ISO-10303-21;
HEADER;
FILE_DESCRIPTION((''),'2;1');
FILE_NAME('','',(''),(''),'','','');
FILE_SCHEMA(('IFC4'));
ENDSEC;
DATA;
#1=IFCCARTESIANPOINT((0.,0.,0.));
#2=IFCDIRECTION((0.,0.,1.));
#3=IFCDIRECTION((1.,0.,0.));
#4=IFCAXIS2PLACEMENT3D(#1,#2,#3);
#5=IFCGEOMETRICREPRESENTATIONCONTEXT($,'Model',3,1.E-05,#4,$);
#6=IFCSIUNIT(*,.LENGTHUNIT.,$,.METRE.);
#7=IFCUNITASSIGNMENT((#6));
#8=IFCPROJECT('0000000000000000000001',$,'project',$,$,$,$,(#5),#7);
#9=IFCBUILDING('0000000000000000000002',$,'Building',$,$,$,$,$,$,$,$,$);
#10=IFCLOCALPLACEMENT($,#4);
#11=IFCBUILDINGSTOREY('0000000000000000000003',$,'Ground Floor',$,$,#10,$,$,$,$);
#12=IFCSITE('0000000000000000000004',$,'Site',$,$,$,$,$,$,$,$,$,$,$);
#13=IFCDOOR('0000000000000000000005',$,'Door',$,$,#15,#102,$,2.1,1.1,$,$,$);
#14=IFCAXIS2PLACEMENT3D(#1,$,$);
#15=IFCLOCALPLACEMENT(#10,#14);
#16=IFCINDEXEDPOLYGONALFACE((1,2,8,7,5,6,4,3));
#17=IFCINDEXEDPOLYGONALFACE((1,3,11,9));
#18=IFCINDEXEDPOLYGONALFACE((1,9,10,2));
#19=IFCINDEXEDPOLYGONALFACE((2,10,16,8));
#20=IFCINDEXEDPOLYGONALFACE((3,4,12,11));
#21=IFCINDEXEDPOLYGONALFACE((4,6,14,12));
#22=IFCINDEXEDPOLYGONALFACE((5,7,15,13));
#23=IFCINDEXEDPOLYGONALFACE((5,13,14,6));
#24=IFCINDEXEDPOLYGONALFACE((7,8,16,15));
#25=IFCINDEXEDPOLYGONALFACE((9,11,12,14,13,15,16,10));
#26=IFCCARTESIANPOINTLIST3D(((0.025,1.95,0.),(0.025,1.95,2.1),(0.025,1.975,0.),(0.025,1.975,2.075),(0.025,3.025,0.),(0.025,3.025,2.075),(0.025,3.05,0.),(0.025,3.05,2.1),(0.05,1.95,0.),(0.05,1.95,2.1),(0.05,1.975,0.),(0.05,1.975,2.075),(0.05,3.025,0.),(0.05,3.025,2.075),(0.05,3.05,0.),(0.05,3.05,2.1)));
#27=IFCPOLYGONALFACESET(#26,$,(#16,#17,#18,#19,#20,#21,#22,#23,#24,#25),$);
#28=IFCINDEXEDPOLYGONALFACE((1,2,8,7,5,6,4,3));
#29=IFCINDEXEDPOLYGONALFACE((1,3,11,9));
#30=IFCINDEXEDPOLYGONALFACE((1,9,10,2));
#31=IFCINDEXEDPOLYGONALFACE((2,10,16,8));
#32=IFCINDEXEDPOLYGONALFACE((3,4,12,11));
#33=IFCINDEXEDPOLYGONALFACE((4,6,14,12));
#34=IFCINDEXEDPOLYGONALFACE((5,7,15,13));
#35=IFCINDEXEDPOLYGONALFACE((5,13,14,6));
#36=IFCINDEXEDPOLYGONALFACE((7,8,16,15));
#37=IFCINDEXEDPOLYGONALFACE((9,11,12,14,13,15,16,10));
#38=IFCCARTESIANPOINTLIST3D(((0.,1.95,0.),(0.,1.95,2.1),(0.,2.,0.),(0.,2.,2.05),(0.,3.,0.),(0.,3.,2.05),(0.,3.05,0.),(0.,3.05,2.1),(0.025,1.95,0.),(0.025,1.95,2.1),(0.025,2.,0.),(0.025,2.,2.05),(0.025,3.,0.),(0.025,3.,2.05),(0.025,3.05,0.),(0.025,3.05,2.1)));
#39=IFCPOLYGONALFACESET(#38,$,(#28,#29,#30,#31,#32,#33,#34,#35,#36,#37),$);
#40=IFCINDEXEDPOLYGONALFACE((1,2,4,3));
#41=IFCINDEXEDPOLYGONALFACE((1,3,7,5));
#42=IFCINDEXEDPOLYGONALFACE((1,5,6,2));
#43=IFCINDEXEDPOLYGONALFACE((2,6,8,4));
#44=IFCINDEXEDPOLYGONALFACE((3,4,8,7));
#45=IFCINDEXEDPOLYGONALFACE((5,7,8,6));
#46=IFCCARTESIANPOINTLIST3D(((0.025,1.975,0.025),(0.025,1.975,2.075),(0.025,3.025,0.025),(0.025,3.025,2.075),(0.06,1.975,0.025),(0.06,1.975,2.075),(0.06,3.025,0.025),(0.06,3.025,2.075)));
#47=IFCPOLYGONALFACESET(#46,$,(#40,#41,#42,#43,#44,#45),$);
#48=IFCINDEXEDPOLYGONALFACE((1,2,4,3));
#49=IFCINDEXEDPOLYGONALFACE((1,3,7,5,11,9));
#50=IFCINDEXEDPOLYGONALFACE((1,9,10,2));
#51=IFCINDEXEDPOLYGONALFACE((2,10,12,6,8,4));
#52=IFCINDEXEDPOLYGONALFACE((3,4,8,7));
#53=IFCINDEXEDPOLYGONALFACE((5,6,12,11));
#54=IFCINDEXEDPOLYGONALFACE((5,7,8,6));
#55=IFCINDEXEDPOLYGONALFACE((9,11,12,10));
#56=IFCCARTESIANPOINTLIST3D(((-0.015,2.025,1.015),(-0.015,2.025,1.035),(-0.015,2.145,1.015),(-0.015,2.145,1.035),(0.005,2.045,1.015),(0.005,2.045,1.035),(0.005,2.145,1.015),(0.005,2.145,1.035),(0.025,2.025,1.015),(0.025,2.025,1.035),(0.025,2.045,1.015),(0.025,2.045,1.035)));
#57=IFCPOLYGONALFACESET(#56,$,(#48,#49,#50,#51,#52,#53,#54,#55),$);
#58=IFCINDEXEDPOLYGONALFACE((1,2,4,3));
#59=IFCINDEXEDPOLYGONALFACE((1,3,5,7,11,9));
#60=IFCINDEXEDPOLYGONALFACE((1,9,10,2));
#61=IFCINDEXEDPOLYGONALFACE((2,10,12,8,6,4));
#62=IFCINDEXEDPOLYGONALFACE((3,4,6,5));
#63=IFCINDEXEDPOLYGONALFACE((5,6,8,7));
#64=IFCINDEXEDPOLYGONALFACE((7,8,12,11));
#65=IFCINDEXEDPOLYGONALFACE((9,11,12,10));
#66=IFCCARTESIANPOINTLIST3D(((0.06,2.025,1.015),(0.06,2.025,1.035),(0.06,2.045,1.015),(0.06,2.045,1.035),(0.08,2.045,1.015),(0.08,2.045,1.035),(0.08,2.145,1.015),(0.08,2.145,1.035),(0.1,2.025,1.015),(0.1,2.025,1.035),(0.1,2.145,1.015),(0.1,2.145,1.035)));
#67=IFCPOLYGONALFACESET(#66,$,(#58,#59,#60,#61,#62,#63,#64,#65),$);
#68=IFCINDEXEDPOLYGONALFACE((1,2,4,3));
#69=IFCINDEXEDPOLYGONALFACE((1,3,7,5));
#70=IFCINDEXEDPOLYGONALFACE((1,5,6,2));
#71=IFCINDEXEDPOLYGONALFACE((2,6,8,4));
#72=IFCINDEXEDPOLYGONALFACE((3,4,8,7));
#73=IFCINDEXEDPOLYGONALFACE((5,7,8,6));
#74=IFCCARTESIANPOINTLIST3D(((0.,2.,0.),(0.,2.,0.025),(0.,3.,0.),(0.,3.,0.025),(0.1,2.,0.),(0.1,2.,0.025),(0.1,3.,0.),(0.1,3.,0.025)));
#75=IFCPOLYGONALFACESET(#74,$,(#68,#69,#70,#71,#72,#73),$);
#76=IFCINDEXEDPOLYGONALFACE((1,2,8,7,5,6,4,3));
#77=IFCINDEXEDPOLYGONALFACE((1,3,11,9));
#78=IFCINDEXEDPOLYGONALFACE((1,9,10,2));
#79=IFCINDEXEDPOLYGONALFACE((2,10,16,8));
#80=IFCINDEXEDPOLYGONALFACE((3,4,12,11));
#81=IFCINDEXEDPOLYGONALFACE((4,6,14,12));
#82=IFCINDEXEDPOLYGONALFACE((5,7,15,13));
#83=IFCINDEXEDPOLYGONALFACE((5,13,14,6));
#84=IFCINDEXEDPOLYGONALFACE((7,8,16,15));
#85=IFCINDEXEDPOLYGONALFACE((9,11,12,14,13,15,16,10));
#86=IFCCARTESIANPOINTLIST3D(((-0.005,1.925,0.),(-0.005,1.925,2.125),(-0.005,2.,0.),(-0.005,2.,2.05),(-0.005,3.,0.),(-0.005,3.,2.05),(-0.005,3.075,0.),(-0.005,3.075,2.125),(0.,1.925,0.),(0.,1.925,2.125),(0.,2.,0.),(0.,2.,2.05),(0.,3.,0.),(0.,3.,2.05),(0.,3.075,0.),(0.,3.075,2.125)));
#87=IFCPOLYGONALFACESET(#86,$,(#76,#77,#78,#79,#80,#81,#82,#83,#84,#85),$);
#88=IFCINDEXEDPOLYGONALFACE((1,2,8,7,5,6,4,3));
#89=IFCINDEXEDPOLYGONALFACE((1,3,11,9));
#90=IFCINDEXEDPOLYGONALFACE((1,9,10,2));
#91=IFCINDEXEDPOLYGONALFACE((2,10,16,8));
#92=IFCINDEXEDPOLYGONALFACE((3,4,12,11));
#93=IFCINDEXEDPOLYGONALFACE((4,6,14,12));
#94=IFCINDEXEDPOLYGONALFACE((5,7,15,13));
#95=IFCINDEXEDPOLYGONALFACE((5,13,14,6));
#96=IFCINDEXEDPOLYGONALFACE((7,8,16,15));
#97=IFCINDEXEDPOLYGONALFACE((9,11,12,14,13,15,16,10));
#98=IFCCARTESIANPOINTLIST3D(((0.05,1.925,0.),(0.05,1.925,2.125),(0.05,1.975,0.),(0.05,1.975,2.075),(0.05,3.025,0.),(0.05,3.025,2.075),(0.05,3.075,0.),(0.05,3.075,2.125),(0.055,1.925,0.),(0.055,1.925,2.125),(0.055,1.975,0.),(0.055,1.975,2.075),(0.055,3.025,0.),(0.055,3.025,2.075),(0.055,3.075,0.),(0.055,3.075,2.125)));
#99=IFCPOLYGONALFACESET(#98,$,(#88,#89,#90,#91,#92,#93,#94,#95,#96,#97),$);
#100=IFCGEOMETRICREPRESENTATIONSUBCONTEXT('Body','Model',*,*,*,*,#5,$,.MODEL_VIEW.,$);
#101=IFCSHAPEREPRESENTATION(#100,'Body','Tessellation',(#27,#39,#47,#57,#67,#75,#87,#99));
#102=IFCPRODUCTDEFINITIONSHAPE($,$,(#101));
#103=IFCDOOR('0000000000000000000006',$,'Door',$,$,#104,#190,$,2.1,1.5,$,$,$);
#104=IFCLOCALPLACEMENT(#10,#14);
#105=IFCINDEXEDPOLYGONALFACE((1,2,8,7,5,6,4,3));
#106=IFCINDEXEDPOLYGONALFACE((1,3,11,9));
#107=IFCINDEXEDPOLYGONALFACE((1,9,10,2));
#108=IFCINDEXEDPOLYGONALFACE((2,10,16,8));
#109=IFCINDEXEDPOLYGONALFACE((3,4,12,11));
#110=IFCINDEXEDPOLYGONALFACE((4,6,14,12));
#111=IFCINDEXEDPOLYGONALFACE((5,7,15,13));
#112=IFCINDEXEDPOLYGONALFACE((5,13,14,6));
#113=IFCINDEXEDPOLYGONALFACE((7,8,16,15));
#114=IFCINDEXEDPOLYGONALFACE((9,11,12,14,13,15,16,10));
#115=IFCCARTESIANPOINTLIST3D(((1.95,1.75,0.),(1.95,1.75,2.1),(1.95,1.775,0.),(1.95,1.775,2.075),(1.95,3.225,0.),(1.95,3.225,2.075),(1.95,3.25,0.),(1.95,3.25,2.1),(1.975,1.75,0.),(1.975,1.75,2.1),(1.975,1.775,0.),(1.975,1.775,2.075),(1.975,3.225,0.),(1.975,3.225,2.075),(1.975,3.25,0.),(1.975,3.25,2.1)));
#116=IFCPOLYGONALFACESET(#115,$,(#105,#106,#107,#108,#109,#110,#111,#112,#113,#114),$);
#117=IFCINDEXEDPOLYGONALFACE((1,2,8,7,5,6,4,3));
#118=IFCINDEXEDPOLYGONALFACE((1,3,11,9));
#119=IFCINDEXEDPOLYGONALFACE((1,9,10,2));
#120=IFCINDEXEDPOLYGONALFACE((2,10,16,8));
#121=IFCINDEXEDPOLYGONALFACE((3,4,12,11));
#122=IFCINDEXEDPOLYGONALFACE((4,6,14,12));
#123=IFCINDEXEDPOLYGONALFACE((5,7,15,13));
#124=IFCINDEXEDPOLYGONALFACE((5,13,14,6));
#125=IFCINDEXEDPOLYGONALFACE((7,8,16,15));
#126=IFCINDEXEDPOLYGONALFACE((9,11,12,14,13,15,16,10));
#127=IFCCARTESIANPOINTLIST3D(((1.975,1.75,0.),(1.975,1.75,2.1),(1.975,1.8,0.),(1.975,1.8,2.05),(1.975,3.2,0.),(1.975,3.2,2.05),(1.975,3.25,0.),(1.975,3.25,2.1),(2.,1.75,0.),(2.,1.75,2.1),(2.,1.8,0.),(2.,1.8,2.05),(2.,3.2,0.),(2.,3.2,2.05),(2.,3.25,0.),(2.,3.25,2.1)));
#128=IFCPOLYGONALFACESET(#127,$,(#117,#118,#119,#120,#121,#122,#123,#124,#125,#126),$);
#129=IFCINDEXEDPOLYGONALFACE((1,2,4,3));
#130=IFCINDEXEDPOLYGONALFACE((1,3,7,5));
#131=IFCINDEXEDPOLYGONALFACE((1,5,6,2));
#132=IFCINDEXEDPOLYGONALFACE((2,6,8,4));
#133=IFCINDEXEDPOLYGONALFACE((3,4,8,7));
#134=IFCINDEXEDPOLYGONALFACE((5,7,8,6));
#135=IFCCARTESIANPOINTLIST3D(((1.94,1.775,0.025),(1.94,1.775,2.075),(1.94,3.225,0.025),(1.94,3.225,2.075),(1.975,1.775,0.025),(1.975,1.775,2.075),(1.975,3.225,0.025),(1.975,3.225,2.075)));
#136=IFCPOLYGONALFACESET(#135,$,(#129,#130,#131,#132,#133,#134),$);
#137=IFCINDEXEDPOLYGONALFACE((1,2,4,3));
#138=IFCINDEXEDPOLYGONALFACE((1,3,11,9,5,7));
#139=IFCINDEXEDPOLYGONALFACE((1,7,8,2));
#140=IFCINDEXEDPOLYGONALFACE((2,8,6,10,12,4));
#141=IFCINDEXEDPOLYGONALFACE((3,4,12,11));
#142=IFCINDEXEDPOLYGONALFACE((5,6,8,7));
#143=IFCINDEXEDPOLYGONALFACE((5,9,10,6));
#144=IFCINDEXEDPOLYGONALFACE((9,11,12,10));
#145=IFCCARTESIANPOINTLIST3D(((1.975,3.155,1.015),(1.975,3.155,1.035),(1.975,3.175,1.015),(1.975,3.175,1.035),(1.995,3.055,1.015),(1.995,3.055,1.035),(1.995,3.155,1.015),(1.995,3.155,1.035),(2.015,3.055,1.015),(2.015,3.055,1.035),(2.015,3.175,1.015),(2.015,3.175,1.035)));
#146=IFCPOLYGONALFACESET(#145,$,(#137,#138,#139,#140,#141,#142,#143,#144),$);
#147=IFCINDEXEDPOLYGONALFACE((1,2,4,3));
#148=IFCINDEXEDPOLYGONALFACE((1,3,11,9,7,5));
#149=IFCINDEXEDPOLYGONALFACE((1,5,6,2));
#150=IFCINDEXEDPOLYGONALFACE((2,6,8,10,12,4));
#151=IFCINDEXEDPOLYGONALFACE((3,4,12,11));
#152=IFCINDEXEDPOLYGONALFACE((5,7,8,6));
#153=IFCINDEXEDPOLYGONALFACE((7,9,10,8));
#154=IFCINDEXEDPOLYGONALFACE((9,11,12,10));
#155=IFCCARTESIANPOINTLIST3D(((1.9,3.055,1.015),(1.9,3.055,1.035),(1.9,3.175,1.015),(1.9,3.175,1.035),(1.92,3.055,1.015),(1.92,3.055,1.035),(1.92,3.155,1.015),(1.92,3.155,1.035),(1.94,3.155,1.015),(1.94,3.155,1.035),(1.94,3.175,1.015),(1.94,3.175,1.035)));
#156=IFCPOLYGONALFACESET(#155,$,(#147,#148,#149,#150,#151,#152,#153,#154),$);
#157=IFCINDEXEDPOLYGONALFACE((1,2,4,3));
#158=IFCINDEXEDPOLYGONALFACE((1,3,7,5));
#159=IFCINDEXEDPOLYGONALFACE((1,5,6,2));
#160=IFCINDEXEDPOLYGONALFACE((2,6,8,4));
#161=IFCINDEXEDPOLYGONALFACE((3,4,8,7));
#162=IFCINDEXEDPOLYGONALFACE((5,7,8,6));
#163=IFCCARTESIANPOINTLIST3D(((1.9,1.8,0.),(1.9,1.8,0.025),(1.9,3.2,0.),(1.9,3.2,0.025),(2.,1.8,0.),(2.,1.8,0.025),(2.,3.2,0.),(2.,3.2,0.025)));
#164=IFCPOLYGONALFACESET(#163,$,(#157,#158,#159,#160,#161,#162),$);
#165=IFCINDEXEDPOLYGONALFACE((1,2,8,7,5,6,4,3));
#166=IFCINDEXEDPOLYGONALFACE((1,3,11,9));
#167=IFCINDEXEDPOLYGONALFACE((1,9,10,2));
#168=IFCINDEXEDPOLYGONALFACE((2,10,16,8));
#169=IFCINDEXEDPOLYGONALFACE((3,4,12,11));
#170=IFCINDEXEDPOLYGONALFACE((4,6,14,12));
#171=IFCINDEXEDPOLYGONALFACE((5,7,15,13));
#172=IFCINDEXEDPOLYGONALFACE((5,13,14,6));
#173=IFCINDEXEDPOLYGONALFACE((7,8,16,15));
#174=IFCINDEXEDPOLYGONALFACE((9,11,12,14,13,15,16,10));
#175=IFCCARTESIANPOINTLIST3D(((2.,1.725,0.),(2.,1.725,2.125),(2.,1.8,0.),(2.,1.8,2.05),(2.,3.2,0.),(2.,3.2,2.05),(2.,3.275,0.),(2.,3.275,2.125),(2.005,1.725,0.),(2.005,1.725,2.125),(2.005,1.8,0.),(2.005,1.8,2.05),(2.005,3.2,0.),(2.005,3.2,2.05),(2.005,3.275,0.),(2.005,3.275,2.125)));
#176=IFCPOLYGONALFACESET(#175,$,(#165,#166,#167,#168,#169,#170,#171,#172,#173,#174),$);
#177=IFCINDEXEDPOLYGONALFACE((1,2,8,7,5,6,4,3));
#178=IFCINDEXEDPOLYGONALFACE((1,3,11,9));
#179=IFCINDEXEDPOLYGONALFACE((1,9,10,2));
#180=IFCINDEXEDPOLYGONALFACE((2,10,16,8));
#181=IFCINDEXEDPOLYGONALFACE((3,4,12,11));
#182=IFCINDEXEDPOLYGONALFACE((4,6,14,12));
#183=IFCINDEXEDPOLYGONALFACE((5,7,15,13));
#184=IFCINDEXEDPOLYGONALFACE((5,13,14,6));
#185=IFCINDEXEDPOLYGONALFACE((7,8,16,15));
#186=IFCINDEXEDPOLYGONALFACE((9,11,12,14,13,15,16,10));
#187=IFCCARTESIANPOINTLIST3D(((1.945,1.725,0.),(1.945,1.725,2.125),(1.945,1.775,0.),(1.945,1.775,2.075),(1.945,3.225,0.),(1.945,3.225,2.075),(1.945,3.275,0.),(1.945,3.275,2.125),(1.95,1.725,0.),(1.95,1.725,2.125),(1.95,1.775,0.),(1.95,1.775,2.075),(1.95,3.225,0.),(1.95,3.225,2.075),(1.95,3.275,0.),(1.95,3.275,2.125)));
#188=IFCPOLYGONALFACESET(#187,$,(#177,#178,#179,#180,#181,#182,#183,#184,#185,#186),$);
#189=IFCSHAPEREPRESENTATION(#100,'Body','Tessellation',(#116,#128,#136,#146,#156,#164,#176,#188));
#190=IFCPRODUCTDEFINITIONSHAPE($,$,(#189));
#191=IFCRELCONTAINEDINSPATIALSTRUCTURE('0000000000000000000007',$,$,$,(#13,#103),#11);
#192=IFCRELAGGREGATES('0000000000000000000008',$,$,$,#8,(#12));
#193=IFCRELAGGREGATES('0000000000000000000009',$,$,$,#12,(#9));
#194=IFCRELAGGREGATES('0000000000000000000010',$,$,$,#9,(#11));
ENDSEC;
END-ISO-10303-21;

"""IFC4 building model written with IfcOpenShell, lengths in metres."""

from ifc_helpers import new_model, si_unit, frame, origin_with_axes, place, context, subcontext, project, spatial, line, indexed_curve, outline, extrude, element, save


model = new_model("IFC4")

# Units and contexts
model_context = context("Model", 3, precision=1e-05, world=origin_with_axes())
body_context = subcontext(model_context, "Body", "Model", "MODEL_VIEW")
ifc_project = project(units=[si_unit("LENGTHUNIT", "METRE")], contexts=[model_context])

# Site, building, storey
site = spatial("IfcSite", under=ifc_project, Name="Site")
building = spatial("IfcBuilding", under=site, Name="Building")
storey_placement = place(None, origin_with_axes())
storey = spatial("IfcBuildingStorey", under=building, at=storey_placement, Name="Ground Floor")

# Doors
door_1_placement = place(storey_placement, frame((0.0, 3.05, 0.0), z_axis=(0.0, 0.0, 1.0), x_axis=(0.0, -1.0, 0.0)))
element("IfcDoor", 1, at=door_1_placement, inside=storey, Name="Door", OverallHeight=2.1, OverallWidth=1.1, context=body_context, shape_type="SweptSolid", body=[
    extrude(outline(indexed_curve([(0.0, 0.0), (0.0, 2.1), (1.1, 2.1), (1.1, 0.0), (1.075, 0.0), (1.075, 2.075), (0.025, 2.075), (0.025, 0.0)], segments=[line(1, 2, 3, 4, 5, 6, 7, 8, 1)])), frame((0.0, 0.025, 0.0), z_axis=(0.0, -1.0, 0.0), x_axis=(1.0, 0.0, 0.0)), (0.0, 0.0, -1.0), 0.025),
    extrude(outline(indexed_curve([(0.0, 0.0), (0.0, 2.1), (1.1, 2.1), (1.1, 0.0), (1.05, 0.0), (1.05, 2.05), (0.05, 2.05), (0.05, 0.0)], segments=[line(1, 2, 3, 4, 5, 6, 7, 8, 1)])), frame((0.0, 0.0, 0.0), z_axis=(0.0, -1.0, 0.0), x_axis=(1.0, 0.0, 0.0)), (0.0, 0.0, -1.0), 0.025),
    extrude(outline(indexed_curve([(0.0, 0.0), (1.05, 0.0), (1.05, 0.035), (0.0, 0.035)], segments=[line(1, 2, 3, 4, 1)])), frame((0.025, 0.025, 0.025), z_axis=(0.0, 0.0, 1.0), x_axis=(1.0, 0.0, 0.0)), (0.0, 0.0, 1.0), 2.05),
    extrude(outline(indexed_curve([(0.0, 0.0), (0.0, -0.04), (-0.12, -0.04), (-0.12, -0.02), (-0.02, -0.02), (-0.02, 0.0)], segments=[line(1, 2, 3, 4, 5, 6, 1)])), frame((1.025, 0.025, 1.015), z_axis=(0.0, 0.0, 1.0), x_axis=(1.0, 0.0, 0.0)), (0.0, 0.0, 1.0), 0.02),
    extrude(outline(indexed_curve([(0.0, 0.0), (0.0, 0.04), (-0.12, 0.04), (-0.12, 0.02), (-0.02, 0.02), (-0.02, 0.0)], segments=[line(1, 2, 3, 4, 5, 6, 1)])), frame((1.025, 0.06, 1.015), z_axis=(0.0, 0.0, 1.0), x_axis=(1.0, 0.0, 0.0)), (0.0, 0.0, 1.0), 0.02),
    extrude(outline(indexed_curve([(0.0, 0.0), (1.0, 0.0), (1.0, 0.1), (0.0, 0.1)], segments=[line(1, 2, 3, 4, 1)])), frame((0.05, 0.0, 0.0), z_axis=(0.0, 0.0, 1.0), x_axis=(1.0, 0.0, 0.0)), (0.0, 0.0, 1.0), 0.025),
    extrude(outline(indexed_curve([(0.0, 0.0), (0.0, 2.125), (1.15, 2.125), (1.15, 0.0), (1.075, 0.0), (1.075, 2.05), (0.075, 2.05), (0.075, 0.0)], segments=[line(1, 2, 3, 4, 5, 6, 7, 8, 1)])), frame((-0.025, -0.005, 0.0), z_axis=(0.0, -1.0, 0.0), x_axis=(1.0, 0.0, 0.0)), (0.0, 0.0, -1.0), 0.005),
    extrude(outline(indexed_curve([(0.0, 0.0), (0.0, 2.125), (1.15, 2.125), (1.15, 0.0), (1.1, 0.0), (1.1, 2.075), (0.05, 2.075), (0.05, 0.0)], segments=[line(1, 2, 3, 4, 5, 6, 7, 8, 1)])), frame((-0.025, 0.05, 0.0), z_axis=(0.0, -1.0, 0.0), x_axis=(1.0, 0.0, 0.0)), (0.0, 0.0, -1.0), 0.005),
])
door_2_placement = place(storey_placement, frame((2.0, 1.75, 0.0), z_axis=(0.0, 0.0, 1.0), x_axis=(0.0, 1.0, 0.0)))
element("IfcDoor", 2, at=door_2_placement, inside=storey, Name="Door", OverallHeight=2.1, OverallWidth=1.5, context=body_context, shape_type="SweptSolid", body=[
    extrude(outline(indexed_curve([(0.0, 0.0), (0.0, 2.1), (1.5, 2.1), (1.5, 0.0), (1.475, 0.0), (1.475, 2.075), (0.025, 2.075), (0.025, 0.0)], segments=[line(1, 2, 3, 4, 5, 6, 7, 8, 1)])), frame((0.0, 0.025, 0.0), z_axis=(0.0, -1.0, 0.0), x_axis=(1.0, 0.0, 0.0)), (0.0, 0.0, -1.0), 0.025),
    extrude(outline(indexed_curve([(0.0, 0.0), (0.0, 2.1), (1.5, 2.1), (1.5, 0.0), (1.45, 0.0), (1.45, 2.05), (0.05, 2.05), (0.05, 0.0)], segments=[line(1, 2, 3, 4, 5, 6, 7, 8, 1)])), frame((0.0, 0.0, 0.0), z_axis=(0.0, -1.0, 0.0), x_axis=(1.0, 0.0, 0.0)), (0.0, 0.0, -1.0), 0.025),
    extrude(outline(indexed_curve([(0.0, 0.0), (1.45, 0.0), (1.45, 0.035), (0.0, 0.035)], segments=[line(1, 2, 3, 4, 1)])), frame((0.025, 0.025, 0.025), z_axis=(0.0, 0.0, 1.0), x_axis=(1.0, 0.0, 0.0)), (0.0, 0.0, 1.0), 2.05),
    extrude(outline(indexed_curve([(0.0, 0.0), (0.0, -0.04), (-0.12, -0.04), (-0.12, -0.02), (-0.02, -0.02), (-0.02, 0.0)], segments=[line(1, 2, 3, 4, 5, 6, 1)])), frame((1.425, 0.025, 1.015), z_axis=(0.0, 0.0, 1.0), x_axis=(1.0, 0.0, 0.0)), (0.0, 0.0, 1.0), 0.02),
    extrude(outline(indexed_curve([(0.0, 0.0), (0.0, 0.04), (-0.12, 0.04), (-0.12, 0.02), (-0.02, 0.02), (-0.02, 0.0)], segments=[line(1, 2, 3, 4, 5, 6, 1)])), frame((1.425, 0.06, 1.015), z_axis=(0.0, 0.0, 1.0), x_axis=(1.0, 0.0, 0.0)), (0.0, 0.0, 1.0), 0.02),
    extrude(outline(indexed_curve([(0.0, 0.0), (1.4, 0.0), (1.4, 0.1), (0.0, 0.1)], segments=[line(1, 2, 3, 4, 1)])), frame((0.05, 0.0, 0.0), z_axis=(0.0, 0.0, 1.0), x_axis=(1.0, 0.0, 0.0)), (0.0, 0.0, 1.0), 0.025),
    extrude(outline(indexed_curve([(0.0, 0.0), (0.0, 2.125), (1.55, 2.125), (1.55, 0.0), (1.475, 0.0), (1.475, 2.05), (0.075, 2.05), (0.075, 0.0)], segments=[line(1, 2, 3, 4, 5, 6, 7, 8, 1)])), frame((-0.025, -0.005, 0.0), z_axis=(0.0, -1.0, 0.0), x_axis=(1.0, 0.0, 0.0)), (0.0, 0.0, -1.0), 0.005),
    extrude(outline(indexed_curve([(0.0, 0.0), (0.0, 2.125), (1.55, 2.125), (1.55, 0.0), (1.5, 0.0), (1.5, 2.075), (0.05, 2.075), (0.05, 0.0)], segments=[line(1, 2, 3, 4, 5, 6, 7, 8, 1)])), frame((-0.025, 0.05, 0.0), z_axis=(0.0, -1.0, 0.0), x_axis=(1.0, 0.0, 0.0)), (0.0, 0.0, -1.0), 0.005),
])

save(model, "model.ifc")
